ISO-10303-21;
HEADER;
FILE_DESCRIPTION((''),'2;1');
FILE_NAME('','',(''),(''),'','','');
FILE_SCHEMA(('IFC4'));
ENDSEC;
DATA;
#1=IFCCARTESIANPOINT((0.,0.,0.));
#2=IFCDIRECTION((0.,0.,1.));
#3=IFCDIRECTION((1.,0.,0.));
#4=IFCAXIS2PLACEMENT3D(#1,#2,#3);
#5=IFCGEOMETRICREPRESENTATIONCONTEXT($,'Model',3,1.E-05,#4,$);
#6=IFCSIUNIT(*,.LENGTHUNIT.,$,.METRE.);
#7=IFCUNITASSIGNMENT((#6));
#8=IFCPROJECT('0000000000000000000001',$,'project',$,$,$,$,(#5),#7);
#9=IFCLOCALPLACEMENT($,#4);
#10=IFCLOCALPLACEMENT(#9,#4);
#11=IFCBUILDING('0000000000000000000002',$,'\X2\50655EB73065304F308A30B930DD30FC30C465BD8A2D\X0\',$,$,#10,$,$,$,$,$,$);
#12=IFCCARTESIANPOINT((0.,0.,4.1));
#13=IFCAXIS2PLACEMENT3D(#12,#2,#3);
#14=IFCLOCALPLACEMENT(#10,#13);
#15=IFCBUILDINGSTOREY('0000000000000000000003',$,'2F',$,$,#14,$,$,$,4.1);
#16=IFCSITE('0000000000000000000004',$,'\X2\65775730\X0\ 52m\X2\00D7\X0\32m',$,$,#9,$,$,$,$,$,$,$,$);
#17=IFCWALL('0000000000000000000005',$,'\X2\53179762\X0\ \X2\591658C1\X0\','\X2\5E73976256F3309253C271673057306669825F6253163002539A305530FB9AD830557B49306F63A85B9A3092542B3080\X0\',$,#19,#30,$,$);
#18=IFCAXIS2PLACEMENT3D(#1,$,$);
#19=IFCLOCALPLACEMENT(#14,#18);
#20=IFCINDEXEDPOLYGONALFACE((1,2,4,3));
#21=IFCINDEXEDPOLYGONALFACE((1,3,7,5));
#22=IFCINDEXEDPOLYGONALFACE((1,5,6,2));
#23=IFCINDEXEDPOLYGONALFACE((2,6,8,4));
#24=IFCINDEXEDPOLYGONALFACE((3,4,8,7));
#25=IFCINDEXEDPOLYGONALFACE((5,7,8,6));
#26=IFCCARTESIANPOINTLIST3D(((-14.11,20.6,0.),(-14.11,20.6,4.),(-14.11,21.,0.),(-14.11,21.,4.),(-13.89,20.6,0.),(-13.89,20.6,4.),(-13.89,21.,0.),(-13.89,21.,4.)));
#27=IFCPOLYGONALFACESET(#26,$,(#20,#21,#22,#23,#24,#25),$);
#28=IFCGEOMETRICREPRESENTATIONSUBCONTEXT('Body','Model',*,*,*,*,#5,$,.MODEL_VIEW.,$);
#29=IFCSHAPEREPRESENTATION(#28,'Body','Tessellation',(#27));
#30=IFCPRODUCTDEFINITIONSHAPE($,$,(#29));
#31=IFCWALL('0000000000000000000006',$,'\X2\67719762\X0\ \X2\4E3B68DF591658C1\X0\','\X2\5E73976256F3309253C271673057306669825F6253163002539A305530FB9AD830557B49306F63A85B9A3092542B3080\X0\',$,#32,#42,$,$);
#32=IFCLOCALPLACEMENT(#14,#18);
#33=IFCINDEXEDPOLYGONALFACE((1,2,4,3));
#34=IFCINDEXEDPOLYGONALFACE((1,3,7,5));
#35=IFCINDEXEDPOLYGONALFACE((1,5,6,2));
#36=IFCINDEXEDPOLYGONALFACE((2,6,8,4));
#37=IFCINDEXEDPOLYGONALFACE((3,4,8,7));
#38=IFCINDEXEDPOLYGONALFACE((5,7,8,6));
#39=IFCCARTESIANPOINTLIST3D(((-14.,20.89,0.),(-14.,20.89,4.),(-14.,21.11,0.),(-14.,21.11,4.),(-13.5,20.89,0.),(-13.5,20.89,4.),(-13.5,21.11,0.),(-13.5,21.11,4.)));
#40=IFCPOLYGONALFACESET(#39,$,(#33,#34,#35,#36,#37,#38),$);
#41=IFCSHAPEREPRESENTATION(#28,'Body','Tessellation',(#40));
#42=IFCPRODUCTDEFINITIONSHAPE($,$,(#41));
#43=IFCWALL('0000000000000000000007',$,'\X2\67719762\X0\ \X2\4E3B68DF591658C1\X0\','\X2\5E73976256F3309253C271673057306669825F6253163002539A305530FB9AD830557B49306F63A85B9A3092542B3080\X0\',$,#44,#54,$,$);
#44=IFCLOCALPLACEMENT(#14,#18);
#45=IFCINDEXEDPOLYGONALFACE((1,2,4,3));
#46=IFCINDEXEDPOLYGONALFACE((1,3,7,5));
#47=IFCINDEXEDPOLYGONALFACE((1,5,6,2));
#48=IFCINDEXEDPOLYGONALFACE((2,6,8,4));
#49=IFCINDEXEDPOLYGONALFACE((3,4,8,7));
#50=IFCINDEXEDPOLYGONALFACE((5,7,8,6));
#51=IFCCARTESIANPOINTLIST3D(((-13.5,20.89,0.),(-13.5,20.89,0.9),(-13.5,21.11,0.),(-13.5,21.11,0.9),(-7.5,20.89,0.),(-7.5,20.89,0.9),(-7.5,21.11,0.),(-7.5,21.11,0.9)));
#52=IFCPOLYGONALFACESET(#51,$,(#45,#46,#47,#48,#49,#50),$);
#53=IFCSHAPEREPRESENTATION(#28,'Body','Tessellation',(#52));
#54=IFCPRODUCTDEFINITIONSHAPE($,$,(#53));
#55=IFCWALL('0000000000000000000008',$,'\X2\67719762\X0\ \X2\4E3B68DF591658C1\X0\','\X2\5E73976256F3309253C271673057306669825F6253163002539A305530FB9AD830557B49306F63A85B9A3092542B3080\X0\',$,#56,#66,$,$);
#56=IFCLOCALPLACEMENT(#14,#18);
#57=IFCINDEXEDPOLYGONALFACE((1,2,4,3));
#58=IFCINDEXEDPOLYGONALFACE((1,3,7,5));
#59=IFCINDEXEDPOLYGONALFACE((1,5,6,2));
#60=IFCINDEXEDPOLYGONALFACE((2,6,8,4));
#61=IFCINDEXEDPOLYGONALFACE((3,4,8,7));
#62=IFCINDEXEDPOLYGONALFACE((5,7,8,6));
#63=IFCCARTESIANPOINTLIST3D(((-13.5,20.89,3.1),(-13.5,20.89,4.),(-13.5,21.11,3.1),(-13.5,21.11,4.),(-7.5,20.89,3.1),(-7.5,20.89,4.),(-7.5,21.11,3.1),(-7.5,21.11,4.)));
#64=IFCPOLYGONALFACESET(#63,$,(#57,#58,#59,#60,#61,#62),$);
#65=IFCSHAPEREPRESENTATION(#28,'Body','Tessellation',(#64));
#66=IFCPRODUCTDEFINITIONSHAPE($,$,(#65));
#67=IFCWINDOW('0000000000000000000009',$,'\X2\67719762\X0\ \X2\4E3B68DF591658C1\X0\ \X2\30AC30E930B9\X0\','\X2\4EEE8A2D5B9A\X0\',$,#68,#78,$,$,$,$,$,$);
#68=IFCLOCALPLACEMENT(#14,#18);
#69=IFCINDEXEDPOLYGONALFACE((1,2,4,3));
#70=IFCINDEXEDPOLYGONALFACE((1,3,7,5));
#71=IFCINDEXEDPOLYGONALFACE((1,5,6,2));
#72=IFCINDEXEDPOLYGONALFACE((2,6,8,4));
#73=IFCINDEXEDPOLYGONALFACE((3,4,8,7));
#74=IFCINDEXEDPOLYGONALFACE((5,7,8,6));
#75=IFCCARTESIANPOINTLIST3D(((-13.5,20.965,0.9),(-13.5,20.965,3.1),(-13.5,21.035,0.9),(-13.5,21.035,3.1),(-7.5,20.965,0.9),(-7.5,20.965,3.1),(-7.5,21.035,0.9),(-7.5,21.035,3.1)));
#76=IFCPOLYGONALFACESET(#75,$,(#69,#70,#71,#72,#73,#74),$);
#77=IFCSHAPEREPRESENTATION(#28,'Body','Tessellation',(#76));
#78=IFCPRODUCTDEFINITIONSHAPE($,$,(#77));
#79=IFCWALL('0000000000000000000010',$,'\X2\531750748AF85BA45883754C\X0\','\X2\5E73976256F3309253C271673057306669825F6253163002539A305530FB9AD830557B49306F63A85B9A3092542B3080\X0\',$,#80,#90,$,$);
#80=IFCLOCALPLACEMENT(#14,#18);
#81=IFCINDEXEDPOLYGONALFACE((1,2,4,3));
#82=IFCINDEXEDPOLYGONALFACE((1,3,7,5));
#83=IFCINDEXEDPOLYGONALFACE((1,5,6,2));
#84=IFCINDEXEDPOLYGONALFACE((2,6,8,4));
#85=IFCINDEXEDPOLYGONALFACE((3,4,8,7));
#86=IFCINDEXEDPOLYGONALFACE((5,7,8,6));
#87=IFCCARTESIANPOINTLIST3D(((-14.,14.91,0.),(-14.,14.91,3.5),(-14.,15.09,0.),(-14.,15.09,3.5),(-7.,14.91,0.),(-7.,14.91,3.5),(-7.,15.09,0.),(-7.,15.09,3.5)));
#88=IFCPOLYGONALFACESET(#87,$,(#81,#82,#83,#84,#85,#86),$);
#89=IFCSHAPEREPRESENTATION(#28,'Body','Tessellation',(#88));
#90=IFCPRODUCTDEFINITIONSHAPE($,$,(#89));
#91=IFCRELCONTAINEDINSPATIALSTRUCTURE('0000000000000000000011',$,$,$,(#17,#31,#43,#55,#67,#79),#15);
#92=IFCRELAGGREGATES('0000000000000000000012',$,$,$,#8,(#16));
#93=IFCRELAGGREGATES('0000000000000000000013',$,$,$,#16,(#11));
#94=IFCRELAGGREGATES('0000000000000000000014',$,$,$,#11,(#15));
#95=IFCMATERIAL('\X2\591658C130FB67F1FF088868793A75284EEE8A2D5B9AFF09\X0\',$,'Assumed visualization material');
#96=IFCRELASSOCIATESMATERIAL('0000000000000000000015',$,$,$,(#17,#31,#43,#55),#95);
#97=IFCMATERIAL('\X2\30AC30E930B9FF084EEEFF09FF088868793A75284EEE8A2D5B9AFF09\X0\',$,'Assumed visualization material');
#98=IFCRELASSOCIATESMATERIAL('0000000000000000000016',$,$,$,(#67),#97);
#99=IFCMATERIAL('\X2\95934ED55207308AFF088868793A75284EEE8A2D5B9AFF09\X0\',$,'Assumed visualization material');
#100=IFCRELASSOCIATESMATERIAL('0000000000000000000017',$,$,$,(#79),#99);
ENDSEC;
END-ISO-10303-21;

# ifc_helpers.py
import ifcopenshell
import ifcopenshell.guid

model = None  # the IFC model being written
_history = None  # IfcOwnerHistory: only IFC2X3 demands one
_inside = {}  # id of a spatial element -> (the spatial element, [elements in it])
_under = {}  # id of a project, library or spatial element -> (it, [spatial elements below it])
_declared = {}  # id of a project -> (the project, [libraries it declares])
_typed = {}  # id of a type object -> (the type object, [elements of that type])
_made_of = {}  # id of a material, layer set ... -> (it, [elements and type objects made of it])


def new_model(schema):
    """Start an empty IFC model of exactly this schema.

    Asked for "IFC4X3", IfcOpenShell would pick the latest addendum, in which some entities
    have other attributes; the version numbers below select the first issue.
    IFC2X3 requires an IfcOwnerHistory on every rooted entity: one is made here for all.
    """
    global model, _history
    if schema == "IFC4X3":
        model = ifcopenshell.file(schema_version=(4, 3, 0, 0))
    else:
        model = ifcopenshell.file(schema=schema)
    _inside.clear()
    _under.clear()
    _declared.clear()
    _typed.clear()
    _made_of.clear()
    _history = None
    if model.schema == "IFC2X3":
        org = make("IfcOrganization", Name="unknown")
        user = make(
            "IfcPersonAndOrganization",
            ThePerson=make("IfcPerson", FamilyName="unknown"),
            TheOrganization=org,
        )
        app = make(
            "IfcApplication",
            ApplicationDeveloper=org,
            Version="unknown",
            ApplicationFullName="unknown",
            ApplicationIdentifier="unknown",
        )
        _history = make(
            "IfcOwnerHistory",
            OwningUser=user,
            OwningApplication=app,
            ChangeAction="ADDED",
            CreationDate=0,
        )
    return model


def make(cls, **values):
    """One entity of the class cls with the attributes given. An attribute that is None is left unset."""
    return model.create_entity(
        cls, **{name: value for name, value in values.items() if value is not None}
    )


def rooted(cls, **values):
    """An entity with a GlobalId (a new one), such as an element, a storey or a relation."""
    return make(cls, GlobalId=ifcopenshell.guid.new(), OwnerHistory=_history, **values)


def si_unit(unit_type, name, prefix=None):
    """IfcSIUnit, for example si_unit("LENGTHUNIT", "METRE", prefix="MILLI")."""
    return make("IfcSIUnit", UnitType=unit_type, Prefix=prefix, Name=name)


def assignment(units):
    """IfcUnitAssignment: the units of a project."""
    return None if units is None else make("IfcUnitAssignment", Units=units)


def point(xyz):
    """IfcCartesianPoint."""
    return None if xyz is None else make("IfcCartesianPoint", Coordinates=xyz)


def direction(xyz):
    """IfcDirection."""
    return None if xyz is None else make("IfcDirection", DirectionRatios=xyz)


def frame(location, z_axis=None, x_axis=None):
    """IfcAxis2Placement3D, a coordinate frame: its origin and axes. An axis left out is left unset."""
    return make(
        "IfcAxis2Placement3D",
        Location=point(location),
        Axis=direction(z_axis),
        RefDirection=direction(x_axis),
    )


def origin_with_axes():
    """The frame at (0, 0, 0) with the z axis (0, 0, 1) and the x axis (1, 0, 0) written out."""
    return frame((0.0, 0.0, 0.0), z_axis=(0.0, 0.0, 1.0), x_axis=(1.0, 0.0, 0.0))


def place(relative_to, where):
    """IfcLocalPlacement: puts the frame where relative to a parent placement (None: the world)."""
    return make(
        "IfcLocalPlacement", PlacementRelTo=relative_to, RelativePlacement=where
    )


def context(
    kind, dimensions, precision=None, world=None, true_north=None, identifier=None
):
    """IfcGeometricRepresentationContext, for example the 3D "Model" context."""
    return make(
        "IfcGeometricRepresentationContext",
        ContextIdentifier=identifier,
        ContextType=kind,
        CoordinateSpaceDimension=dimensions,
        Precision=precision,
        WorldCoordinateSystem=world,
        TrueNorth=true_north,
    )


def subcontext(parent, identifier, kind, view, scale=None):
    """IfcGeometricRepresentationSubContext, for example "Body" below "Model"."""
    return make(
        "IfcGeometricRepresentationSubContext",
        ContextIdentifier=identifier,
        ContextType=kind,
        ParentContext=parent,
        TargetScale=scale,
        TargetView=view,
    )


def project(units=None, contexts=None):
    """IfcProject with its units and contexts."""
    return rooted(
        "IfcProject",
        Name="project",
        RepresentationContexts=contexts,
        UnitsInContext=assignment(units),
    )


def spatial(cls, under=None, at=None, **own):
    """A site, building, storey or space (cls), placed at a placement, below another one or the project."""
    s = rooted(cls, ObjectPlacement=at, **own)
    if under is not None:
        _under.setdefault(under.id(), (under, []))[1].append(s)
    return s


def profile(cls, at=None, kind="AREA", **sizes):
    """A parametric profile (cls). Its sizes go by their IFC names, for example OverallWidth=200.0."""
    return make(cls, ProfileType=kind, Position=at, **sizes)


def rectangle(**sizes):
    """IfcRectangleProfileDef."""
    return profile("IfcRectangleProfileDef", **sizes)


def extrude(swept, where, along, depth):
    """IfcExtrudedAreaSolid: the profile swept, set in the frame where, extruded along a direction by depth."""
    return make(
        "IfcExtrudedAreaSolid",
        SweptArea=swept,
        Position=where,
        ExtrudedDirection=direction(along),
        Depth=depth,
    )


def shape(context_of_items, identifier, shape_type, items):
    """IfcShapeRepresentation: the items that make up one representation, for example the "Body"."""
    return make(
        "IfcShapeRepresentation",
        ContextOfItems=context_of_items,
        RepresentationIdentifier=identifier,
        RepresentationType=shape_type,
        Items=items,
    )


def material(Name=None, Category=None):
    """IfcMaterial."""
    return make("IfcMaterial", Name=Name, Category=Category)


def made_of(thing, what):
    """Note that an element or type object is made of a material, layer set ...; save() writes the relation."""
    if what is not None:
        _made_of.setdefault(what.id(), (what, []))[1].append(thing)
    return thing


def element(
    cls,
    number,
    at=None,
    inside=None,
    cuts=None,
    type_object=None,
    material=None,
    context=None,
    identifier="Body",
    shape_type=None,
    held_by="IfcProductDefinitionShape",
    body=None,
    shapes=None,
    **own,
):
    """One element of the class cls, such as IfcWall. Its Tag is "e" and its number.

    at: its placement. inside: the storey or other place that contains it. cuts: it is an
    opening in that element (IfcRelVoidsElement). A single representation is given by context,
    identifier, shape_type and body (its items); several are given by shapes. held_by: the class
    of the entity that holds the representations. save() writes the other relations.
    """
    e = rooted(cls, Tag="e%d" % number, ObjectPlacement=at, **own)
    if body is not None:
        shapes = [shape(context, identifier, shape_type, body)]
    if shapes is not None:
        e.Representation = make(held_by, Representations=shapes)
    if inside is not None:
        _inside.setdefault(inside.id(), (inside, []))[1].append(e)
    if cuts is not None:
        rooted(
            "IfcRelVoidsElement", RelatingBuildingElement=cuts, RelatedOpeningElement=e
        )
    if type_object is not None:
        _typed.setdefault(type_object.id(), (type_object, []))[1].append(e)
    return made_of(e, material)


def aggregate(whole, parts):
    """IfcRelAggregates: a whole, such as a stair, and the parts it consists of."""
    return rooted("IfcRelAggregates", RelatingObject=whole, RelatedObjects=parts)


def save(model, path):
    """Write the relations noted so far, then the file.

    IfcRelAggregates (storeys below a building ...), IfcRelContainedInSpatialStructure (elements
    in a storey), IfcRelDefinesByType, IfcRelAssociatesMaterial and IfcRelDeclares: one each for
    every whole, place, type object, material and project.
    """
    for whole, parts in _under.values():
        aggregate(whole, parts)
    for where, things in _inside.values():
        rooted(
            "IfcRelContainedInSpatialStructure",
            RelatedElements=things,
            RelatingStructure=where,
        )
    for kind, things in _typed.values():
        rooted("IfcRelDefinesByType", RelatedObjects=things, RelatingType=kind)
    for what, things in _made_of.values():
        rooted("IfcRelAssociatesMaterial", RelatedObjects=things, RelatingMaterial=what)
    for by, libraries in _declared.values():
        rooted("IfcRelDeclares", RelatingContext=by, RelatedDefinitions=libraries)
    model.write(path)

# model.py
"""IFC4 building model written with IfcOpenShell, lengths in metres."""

from ifc_helpers import new_model, si_unit, frame, origin_with_axes, place, context, subcontext, project, spatial, rectangle, extrude, material, element, save


model = new_model("IFC4")

# Units and contexts
model_context = context("Model", 3, precision=1e-05, world=origin_with_axes())
body_context = subcontext(model_context, "Body", "Model", "MODEL_VIEW")
ifc_project = project(units=[si_unit("LENGTHUNIT", "METRE")], contexts=[model_context])

# Site, building, storey
site_placement = place(None, origin_with_axes())
site = spatial("IfcSite", under=ifc_project, at=site_placement, Name="敷地 52m×32m")
building_placement = place(site_placement, origin_with_axes())
building = spatial("IfcBuilding", under=site, at=building_placement, Name="健康づくりスポーツ施設")
storey_placement = place(building_placement, frame((0.0, 0.0, 4.1), z_axis=(0.0, 0.0, 1.0), x_axis=(1.0, 0.0, 0.0)))
storey = spatial("IfcBuildingStorey", under=building, at=storey_placement, Name="2F", Elevation=4.1)

# Shared definitions
ifc_material_1 = material(Name="外壁・柱（表示用仮設定）", Category="Assumed visualization material")

# Shared definitions
ifc_material_2 = material(Name="ガラス（仮）（表示用仮設定）", Category="Assumed visualization material")

# Walls
wall_1_placement = place(storey_placement, frame((-14.0, 20.8, 0.0), z_axis=(0.0, 0.0, 1.0), x_axis=(1.0, 0.0, 0.0)))
element("IfcWall", 1, at=wall_1_placement, inside=storey, material=ifc_material_1, Name="北面 外壁", Description="平面図を参照して概形化。厚さ・高さ等は推定を含む", context=body_context, shape_type="SweptSolid", body=[
    extrude(rectangle(XDim=0.22, YDim=0.4), origin_with_axes(), (0.0, 0.0, 1.0), 4.0),
])
wall_2_placement = place(storey_placement, frame((-13.75, 21.0, 0.0), z_axis=(0.0, 0.0, 1.0), x_axis=(1.0, 0.0, 0.0)))
element("IfcWall", 2, at=wall_2_placement, inside=storey, material=ifc_material_1, Name="東面 主棟外壁", Description="平面図を参照して概形化。厚さ・高さ等は推定を含む", context=body_context, shape_type="SweptSolid", body=[
    extrude(rectangle(XDim=0.5, YDim=0.22), origin_with_axes(), (0.0, 0.0, 1.0), 4.0),
])
for number, where, z_axis, x_axis, name in (
    (3, (-10.5, 21.0, 0.0), (0.0, 0.0, 1.0), (1.0, 0.0, 0.0), "東面 主棟外壁"),
    (4, (-10.5, 21.0, 3.1), (0.0, 0.0, 1.0), (1.0, 0.0, 0.0), "東面 主棟外壁"),
):
    element("IfcWall", number, at=place(storey_placement, frame(where, z_axis=z_axis, x_axis=x_axis)), inside=storey, material=ifc_material_1, Name=name, Description="平面図を参照して概形化。厚さ・高さ等は推定を含む", context=body_context, shape_type="SweptSolid", body=[
        extrude(rectangle(XDim=6.0, YDim=0.22), origin_with_axes(), (0.0, 0.0, 1.0), 0.9),
    ])

# Window
window_1_placement = place(storey_placement, frame((-10.5, 21.0, 0.9), z_axis=(0.0, 0.0, 1.0), x_axis=(1.0, 0.0, 0.0)))
element("IfcWindow", 5, at=window_1_placement, inside=storey, material=ifc_material_2, Name="東面 主棟外壁 ガラス", Description="仮設定", context=body_context, shape_type="SweptSolid", body=[
    extrude(rectangle(XDim=6.0, YDim=0.07), origin_with_axes(), (0.0, 0.0, 1.0), 2.2),
])

# Wall
ifc_material_3 = material(Name="間仕切り（表示用仮設定）", Category="Assumed visualization material")
wall_3_placement = place(storey_placement, frame((-10.5, 15.0, 0.0), z_axis=(0.0, 0.0, 1.0), x_axis=(1.0, 0.0, 0.0)))
element("IfcWall", 6, at=wall_3_placement, inside=storey, material=ifc_material_3, Name="北側諸室境界", Description="平面図を参照して概形化。厚さ・高さ等は推定を含む", context=body_context, shape_type="SweptSolid", body=[
    extrude(rectangle(XDim=7.0, YDim=0.18), origin_with_axes(), (0.0, 0.0, 1.0), 3.5),
])

save(model, "model.ifc")
